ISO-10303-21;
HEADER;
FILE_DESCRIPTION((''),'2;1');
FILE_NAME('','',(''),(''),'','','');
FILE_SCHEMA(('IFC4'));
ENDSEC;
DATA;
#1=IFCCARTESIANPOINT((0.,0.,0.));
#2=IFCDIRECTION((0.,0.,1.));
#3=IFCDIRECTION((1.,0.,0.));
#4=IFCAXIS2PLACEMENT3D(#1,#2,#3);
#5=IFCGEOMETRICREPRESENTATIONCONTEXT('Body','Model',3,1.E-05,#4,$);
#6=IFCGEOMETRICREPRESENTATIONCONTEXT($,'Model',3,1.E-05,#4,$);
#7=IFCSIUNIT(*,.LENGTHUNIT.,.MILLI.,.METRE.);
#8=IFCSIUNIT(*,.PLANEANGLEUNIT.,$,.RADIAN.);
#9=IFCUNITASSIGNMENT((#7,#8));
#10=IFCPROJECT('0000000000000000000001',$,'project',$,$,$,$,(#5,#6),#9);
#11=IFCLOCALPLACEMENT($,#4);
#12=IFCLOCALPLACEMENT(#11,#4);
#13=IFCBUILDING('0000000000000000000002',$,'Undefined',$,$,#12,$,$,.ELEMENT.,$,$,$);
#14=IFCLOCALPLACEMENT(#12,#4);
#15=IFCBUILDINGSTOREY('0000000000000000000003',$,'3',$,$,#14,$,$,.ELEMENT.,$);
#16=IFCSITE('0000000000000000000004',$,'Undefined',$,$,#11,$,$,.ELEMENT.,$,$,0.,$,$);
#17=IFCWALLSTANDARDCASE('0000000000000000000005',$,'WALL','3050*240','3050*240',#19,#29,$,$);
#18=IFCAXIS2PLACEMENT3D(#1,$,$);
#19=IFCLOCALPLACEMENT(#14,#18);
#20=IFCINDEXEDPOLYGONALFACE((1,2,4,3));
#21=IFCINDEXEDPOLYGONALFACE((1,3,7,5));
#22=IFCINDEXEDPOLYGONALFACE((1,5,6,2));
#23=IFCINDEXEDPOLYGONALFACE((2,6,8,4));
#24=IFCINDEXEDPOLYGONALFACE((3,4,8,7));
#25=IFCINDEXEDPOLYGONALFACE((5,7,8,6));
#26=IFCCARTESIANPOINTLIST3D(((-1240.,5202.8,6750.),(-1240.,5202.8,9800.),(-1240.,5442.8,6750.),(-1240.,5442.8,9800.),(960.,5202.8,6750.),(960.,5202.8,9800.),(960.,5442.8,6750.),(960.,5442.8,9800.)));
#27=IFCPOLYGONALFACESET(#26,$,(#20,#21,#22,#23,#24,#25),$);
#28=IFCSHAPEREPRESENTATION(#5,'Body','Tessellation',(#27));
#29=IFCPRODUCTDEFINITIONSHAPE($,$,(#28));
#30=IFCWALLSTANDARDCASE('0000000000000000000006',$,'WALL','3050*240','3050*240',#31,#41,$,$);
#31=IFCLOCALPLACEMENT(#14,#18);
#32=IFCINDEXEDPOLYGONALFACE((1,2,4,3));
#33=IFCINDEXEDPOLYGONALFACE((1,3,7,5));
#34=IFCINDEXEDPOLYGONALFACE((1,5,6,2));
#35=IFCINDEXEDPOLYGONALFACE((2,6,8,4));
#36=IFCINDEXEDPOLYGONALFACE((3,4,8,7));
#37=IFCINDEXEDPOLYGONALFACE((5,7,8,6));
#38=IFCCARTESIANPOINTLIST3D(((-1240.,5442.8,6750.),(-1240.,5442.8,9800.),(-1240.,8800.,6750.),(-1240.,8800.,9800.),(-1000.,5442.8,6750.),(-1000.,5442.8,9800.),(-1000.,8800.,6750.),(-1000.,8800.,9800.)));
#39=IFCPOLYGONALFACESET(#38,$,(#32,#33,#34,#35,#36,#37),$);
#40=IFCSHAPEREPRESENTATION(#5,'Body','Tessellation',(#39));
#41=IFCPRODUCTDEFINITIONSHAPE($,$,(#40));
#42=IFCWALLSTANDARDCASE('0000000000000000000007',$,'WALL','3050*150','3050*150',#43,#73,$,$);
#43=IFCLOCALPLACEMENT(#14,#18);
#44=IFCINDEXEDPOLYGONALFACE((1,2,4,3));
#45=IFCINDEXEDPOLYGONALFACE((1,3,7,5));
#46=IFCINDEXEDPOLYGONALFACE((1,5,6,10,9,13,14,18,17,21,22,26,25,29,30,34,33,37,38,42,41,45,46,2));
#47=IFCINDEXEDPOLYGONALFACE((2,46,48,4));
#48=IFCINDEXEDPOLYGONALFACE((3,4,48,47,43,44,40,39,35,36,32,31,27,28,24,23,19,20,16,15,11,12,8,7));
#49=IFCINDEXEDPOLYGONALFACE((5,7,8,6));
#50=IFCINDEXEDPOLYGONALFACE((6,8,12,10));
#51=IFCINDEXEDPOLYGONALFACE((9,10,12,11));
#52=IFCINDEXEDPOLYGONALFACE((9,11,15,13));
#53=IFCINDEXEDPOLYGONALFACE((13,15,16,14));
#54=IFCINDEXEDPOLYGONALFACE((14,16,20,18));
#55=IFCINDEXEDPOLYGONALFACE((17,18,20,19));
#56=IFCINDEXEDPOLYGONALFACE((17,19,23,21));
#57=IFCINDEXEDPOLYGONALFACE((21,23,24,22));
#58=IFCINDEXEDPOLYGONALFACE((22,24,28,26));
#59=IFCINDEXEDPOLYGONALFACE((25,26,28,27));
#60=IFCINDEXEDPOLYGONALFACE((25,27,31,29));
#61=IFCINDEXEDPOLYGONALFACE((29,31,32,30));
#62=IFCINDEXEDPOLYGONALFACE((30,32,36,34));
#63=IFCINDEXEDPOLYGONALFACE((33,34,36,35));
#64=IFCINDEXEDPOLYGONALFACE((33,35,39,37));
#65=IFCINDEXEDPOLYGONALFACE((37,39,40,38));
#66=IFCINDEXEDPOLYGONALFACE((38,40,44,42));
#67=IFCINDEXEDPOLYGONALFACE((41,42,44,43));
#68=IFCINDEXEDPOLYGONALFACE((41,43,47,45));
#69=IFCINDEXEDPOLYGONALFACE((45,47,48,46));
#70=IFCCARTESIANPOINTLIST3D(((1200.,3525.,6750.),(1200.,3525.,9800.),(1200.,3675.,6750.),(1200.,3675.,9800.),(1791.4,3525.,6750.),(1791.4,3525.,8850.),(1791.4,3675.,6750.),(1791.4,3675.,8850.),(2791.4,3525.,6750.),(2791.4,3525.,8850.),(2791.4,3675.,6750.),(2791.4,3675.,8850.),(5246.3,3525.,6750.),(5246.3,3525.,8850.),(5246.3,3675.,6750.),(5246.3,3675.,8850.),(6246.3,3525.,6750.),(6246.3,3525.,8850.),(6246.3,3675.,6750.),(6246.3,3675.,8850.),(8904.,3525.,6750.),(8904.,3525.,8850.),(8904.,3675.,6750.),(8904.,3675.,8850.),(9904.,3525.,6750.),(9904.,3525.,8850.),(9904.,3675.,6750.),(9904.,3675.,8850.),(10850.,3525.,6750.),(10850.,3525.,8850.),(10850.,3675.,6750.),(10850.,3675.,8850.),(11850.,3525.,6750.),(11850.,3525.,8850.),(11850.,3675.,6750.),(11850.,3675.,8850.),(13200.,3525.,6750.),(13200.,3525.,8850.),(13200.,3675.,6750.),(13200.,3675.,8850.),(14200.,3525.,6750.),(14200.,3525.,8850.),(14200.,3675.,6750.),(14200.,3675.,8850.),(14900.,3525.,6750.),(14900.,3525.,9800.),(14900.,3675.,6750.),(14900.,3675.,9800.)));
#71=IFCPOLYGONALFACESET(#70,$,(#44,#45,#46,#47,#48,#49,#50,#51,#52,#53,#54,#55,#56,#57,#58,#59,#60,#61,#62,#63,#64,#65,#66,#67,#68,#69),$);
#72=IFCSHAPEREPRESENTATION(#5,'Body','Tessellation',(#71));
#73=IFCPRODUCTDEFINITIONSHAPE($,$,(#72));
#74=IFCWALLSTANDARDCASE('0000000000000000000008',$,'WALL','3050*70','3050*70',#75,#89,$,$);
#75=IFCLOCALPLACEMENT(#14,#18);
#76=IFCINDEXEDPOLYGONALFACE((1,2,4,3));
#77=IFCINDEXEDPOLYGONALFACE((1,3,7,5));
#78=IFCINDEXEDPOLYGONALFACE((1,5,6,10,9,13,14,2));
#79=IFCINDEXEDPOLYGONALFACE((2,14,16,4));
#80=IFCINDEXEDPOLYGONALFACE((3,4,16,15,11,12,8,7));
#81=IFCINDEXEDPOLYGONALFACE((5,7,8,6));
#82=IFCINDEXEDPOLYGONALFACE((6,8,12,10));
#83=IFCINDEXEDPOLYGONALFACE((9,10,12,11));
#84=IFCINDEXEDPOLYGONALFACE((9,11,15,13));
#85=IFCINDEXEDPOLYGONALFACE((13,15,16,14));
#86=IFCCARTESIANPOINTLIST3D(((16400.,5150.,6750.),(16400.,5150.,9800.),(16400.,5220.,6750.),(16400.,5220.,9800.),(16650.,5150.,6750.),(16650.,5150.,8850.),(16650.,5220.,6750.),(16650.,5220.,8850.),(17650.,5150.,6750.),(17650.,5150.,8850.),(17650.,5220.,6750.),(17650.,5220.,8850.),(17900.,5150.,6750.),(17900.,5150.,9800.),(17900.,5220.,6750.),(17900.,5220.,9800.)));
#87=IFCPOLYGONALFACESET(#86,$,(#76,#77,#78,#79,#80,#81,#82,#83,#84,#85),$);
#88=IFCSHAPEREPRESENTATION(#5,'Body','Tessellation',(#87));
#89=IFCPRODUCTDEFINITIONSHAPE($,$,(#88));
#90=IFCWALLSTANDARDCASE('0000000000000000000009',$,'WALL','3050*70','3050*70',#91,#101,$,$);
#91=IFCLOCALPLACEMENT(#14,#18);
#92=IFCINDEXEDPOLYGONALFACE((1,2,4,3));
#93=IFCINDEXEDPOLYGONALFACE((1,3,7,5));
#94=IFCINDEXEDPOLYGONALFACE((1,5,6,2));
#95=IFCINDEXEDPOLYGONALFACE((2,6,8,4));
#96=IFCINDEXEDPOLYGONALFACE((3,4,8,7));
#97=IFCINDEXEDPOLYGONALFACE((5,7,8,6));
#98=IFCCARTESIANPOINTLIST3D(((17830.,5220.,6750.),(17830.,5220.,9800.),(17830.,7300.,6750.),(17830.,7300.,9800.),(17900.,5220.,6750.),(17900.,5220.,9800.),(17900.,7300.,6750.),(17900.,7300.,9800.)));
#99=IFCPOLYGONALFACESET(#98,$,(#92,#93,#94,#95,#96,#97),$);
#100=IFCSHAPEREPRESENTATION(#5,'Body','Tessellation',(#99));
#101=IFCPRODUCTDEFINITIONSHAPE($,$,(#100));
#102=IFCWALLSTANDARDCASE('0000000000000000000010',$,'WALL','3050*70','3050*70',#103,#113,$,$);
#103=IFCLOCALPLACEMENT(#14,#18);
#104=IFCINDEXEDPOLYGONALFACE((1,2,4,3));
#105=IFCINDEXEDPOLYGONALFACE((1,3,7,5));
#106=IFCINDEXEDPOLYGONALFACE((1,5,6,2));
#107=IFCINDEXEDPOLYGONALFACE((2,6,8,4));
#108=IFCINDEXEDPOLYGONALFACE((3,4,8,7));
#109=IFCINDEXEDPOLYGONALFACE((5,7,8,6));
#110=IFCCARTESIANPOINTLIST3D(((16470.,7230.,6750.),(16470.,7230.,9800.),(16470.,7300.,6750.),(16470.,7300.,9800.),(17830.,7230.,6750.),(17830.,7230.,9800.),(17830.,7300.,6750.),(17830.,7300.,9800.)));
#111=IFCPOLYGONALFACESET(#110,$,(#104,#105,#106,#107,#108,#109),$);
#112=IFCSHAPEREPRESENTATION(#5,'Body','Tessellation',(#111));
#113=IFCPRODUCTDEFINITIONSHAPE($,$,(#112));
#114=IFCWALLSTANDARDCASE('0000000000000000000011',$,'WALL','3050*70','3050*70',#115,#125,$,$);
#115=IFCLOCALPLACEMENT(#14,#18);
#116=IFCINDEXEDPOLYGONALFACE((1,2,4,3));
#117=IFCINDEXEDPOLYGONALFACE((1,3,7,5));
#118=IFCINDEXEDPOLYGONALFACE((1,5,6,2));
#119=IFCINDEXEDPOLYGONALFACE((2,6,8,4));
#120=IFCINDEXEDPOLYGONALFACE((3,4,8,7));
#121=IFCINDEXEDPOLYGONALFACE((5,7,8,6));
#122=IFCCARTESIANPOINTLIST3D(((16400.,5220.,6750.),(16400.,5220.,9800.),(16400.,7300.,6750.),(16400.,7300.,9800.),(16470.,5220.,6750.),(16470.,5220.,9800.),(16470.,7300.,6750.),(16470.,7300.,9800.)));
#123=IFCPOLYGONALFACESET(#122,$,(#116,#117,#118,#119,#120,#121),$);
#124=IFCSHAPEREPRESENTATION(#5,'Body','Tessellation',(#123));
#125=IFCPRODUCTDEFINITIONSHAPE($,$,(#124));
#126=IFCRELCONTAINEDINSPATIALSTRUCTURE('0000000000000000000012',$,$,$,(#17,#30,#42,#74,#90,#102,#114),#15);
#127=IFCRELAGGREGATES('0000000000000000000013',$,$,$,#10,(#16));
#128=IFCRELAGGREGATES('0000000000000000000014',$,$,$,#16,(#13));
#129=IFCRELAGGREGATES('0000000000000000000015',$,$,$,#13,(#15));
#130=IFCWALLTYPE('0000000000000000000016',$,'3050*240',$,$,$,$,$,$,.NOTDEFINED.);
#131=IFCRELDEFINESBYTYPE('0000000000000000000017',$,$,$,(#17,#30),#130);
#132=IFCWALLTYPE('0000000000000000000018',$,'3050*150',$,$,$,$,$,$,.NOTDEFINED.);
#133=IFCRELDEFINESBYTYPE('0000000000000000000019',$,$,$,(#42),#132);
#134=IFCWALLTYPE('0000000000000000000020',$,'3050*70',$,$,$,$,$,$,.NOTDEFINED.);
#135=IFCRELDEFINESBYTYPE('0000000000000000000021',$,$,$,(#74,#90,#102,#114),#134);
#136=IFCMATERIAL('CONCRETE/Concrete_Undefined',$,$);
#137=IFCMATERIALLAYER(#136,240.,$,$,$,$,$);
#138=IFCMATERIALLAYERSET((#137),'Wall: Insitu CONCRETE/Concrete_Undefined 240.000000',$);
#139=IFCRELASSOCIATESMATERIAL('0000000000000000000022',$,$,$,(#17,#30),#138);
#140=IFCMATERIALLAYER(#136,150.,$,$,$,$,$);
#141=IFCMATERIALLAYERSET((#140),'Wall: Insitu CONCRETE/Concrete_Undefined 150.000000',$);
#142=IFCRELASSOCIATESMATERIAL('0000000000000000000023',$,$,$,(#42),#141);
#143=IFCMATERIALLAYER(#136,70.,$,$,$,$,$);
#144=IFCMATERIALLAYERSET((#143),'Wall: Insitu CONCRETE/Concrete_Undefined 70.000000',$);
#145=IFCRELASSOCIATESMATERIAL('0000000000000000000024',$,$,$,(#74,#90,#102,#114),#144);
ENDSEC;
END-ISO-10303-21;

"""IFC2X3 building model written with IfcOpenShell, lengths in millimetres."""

from ifc_helpers import new_model, si_unit, frame, frame_2d, origin_with_axes, place, context, project, spatial, polyline, rectangle, outline, extrude, material, layer, layer_set, layer_usage, type_object, element, save


model = new_model("IFC2X3")

# Units and contexts
model_context_1 = context("Model", 3, precision=1e-05, world=origin_with_axes(), identifier="Body")
model_context_2 = context("Model", 3, precision=1e-05, world=origin_with_axes())
ifc_project = project(units=[si_unit("LENGTHUNIT", "METRE", prefix="MILLI"), si_unit("PLANEANGLEUNIT", "RADIAN")], contexts=[model_context_1, model_context_2])

# Site, building, storey
site_placement = place(None, origin_with_axes())
site = spatial("IfcSite", under=ifc_project, at=site_placement, Name="Undefined", CompositionType="ELEMENT", RefElevation=0.0)
building_placement = place(site_placement, origin_with_axes())
building = spatial("IfcBuilding", under=site, at=building_placement, Name="Undefined", CompositionType="ELEMENT")
storey_placement = place(building_placement, origin_with_axes())
storey = spatial("IfcBuildingStorey", under=building, at=storey_placement, Name="3", CompositionType="ELEMENT")

# Shared definitions
ifc_material = material(Name="CONCRETE/Concrete_Undefined")

# Shared definitions
ifc_layer_1 = layer(ifc_material, 240.0)
ifc_layer_set_1 = layer_set([ifc_layer_1], Name="Wall: Insitu CONCRETE/Concrete_Undefined 240.000000")
wall_type_1 = type_object("IfcWallType", Name="3050*240", PredefinedType="NOTDEFINED")

# Walls
ifc_layer_usage_1 = layer_usage(ifc_layer_set_1, "AXIS2", "POSITIVE", -120.0)
wall_1_placement = place(storey_placement, frame((960.0, 5322.8, 6750.0), z_axis=(0.0, 0.0, 1.0), x_axis=(-1.0, 0.0, 0.0)))
element("IfcWallStandardCase", 1, at=wall_1_placement, inside=storey, type_object=wall_type_1, material=ifc_layer_usage_1, Name="WALL", Description="3050*240", ObjectType="3050*240", context=model_context_1, shape_type="SweptSolid", body=[
    extrude(rectangle(XDim=2200.0, YDim=240.0, at=frame_2d((0.0, 1100.0), x_axis=(0.0, -1.0))), frame((0.0, 0.0, 0.0), z_axis=(0.0, 0.0, 1.0), x_axis=(0.0, -1.0, 0.0)), (0.0, 0.0, 1.0), 3050.0),
])
ifc_layer_usage_2 = layer_usage(ifc_layer_set_1, "AXIS2", "POSITIVE", -120.0)
wall_2_placement = place(storey_placement, frame((-1120.0, 5442.8, 6750.0), z_axis=(0.0, 0.0, 1.0), x_axis=(0.0, 1.0, 0.0)))
element("IfcWallStandardCase", 2, at=wall_2_placement, inside=storey, type_object=wall_type_1, material=ifc_layer_usage_2, Name="WALL", Description="3050*240", ObjectType="3050*240", context=model_context_1, shape_type="SweptSolid", body=[
    extrude(rectangle(XDim=3357.2, YDim=240.0, at=frame_2d((0.0, 1678.6), x_axis=(0.0, -1.0))), frame((0.0, 0.0, 0.0), z_axis=(0.0, 0.0, 1.0), x_axis=(0.0, -1.0, 0.0)), (0.0, 0.0, 1.0), 3050.0),
])

# Wall, openings
ifc_layer_2 = layer(ifc_material, 150.0)
ifc_layer_set_2 = layer_set([ifc_layer_2], Name="Wall: Insitu CONCRETE/Concrete_Undefined 150.000000")
ifc_layer_usage_3 = layer_usage(ifc_layer_set_2, "AXIS2", "POSITIVE", -75.0)
wall_type_2 = type_object("IfcWallType", Name="3050*150", PredefinedType="NOTDEFINED")
wall_3_placement = place(storey_placement, frame((1200.0, 3600.0, 6750.0), z_axis=(0.0, 0.0, 1.0), x_axis=(1.0, 0.0, 0.0)))
wall_3 = element("IfcWallStandardCase", 3, at=wall_3_placement, inside=storey, type_object=wall_type_2, material=ifc_layer_usage_3, Name="WALL", Description="3050*150", ObjectType="3050*150", context=model_context_1, shape_type="SweptSolid", body=[
    extrude(rectangle(XDim=13700.0, YDim=150.0, at=frame_2d((0.0, 6850.0), x_axis=(0.0, -1.0))), frame((0.0, 0.0, 0.0), z_axis=(0.0, 0.0, 1.0), x_axis=(0.0, -1.0, 0.0)), (0.0, 0.0, 1.0), 3050.0),
])
opening_1_placement = place(storey_placement, frame((1200.0, 3600.0, 6750.0), z_axis=(0.0, 0.0, 1.0), x_axis=(1.0, 0.0, 0.0)))
element("IfcOpeningElement", 4, at=opening_1_placement, cuts=wall_3, ObjectType="Recess", context=model_context_1, shape_type="SweptSolid", body=[
    extrude(outline(polyline([(0.0, 0.0), (1000.0, 0.0), (1000.0, 2100.0), (0.0, 2100.0), (0.0, 0.0)])), frame((591.4, -78.0, 2100.0), z_axis=(0.0, 1.0, 0.0), x_axis=(1.0, 0.0, 0.0)), (0.0, 0.0, 1.0), 156.0),
])
opening_2_placement = place(storey_placement, frame((1200.0, 3600.0, 6750.0), z_axis=(0.0, 0.0, 1.0), x_axis=(1.0, 0.0, 0.0)))
element("IfcOpeningElement", 5, at=opening_2_placement, cuts=wall_3, ObjectType="Recess", context=model_context_1, shape_type="SweptSolid", body=[
    extrude(outline(polyline([(0.0, 0.0), (1000.0, 0.0), (1000.0, 2100.0), (0.0, 2100.0), (0.0, 0.0)])), frame((4046.3, -78.0, 2100.0), z_axis=(0.0, 1.0, 0.0), x_axis=(1.0, 0.0, 0.0)), (0.0, 0.0, 1.0), 156.0),
])
opening_3_placement = place(storey_placement, frame((1200.0, 3600.0, 6750.0), z_axis=(0.0, 0.0, 1.0), x_axis=(1.0, 0.0, 0.0)))
element("IfcOpeningElement", 6, at=opening_3_placement, cuts=wall_3, ObjectType="Recess", context=model_context_1, shape_type="SweptSolid", body=[
    extrude(outline(polyline([(0.0, 0.0), (1000.0, 0.0), (1000.0, 2100.0), (0.0, 2100.0), (0.0, 0.0)])), frame((7704.0, -78.0, 2100.0), z_axis=(0.0, 1.0, 0.0), x_axis=(1.0, 0.0, 0.0)), (0.0, 0.0, 1.0), 156.0),
])
opening_4_placement = place(storey_placement, frame((1200.0, 3600.0, 6750.0), z_axis=(0.0, 0.0, 1.0), x_axis=(1.0, 0.0, 0.0)))
element("IfcOpeningElement", 7, at=opening_4_placement, cuts=wall_3, ObjectType="Recess", context=model_context_1, shape_type="SweptSolid", body=[
    extrude(outline(polyline([(0.0, 0.0), (1000.0, 0.0), (1000.0, 2100.0), (0.0, 2100.0), (0.0, 0.0)])), frame((9650.0, -78.0, 2100.0), z_axis=(0.0, 1.0, 0.0), x_axis=(1.0, 0.0, 0.0)), (0.0, 0.0, 1.0), 156.0),
])
opening_5_placement = place(storey_placement, frame((1200.0, 3600.0, 6750.0), z_axis=(0.0, 0.0, 1.0), x_axis=(1.0, 0.0, 0.0)))
element("IfcOpeningElement", 8, at=opening_5_placement, cuts=wall_3, ObjectType="Recess", context=model_context_1, shape_type="SweptSolid", body=[
    extrude(outline(polyline([(0.0, 0.0), (1000.0, 0.0), (1000.0, 2100.0), (0.0, 2100.0), (0.0, 0.0)])), frame((12000.0, -78.0, 2100.0), z_axis=(0.0, 1.0, 0.0), x_axis=(1.0, 0.0, 0.0)), (0.0, 0.0, 1.0), 156.0),
])

# Wall, opening
ifc_layer_3 = layer(ifc_material, 70.0)
ifc_layer_set_3 = layer_set([ifc_layer_3], Name="Wall: Insitu CONCRETE/Concrete_Undefined 70.000000")
ifc_layer_usage_4 = layer_usage(ifc_layer_set_3, "AXIS2", "POSITIVE", -35.0)
wall_type_3 = type_object("IfcWallType", Name="3050*70", PredefinedType="NOTDEFINED")
wall_4_placement = place(storey_placement, frame((16400.0, 5185.0, 6750.0), z_axis=(0.0, 0.0, 1.0), x_axis=(1.0, 0.0, 0.0)))
wall_4 = element("IfcWallStandardCase", 9, at=wall_4_placement, inside=storey, type_object=wall_type_3, material=ifc_layer_usage_4, Name="WALL", Description="3050*70", ObjectType="3050*70", context=model_context_1, shape_type="SweptSolid", body=[
    extrude(rectangle(XDim=1500.0, YDim=70.0, at=frame_2d((0.0, 750.0), x_axis=(0.0, -1.0))), frame((0.0, 0.0, 0.0), z_axis=(0.0, 0.0, 1.0), x_axis=(0.0, -1.0, 0.0)), (0.0, 0.0, 1.0), 3050.0),
])
opening_6_placement = place(storey_placement, frame((16400.0, 5185.0, 6750.0), z_axis=(0.0, 0.0, 1.0), x_axis=(1.0, 0.0, 0.0)))
element("IfcOpeningElement", 10, at=opening_6_placement, cuts=wall_4, ObjectType="Recess", context=model_context_1, shape_type="SweptSolid", body=[
    extrude(outline(polyline([(0.0, 0.0), (2100.0, 0.0), (2100.0, 1000.0), (0.0, 1000.0), (0.0, 0.0)])), frame((250.0, -38.0, 0.0), z_axis=(0.0, 1.0, 0.0), x_axis=(0.0, 0.0, 1.0)), (0.0, 0.0, 1.0), 76.0),
])

# Walls
ifc_layer_usage_5 = layer_usage(ifc_layer_set_3, "AXIS2", "POSITIVE", -35.0)
wall_5_placement = place(storey_placement, frame((17865.0, 5220.0, 6750.0), z_axis=(0.0, 0.0, 1.0), x_axis=(0.0, 1.0, 0.0)))
element("IfcWallStandardCase", 11, at=wall_5_placement, inside=storey, type_object=wall_type_3, material=ifc_layer_usage_5, Name="WALL", Description="3050*70", ObjectType="3050*70", context=model_context_1, shape_type="SweptSolid", body=[
    extrude(rectangle(XDim=2080.0, YDim=70.0, at=frame_2d((0.0, 1040.0), x_axis=(0.0, -1.0))), frame((0.0, 0.0, 0.0), z_axis=(0.0, 0.0, 1.0), x_axis=(0.0, -1.0, 0.0)), (0.0, 0.0, 1.0), 3050.0),
])
ifc_layer_usage_6 = layer_usage(ifc_layer_set_3, "AXIS2", "POSITIVE", -35.0)
wall_6_placement = place(storey_placement, frame((17830.0, 7265.0, 6750.0), z_axis=(0.0, 0.0, 1.0), x_axis=(-1.0, 0.0, 0.0)))
element("IfcWallStandardCase", 12, at=wall_6_placement, inside=storey, type_object=wall_type_3, material=ifc_layer_usage_6, Name="WALL", Description="3050*70", ObjectType="3050*70", context=model_context_1, shape_type="SweptSolid", body=[
    extrude(rectangle(XDim=1360.0, YDim=70.0, at=frame_2d((0.0, 680.0), x_axis=(0.0, -1.0))), frame((0.0, 0.0, 0.0), z_axis=(0.0, 0.0, 1.0), x_axis=(0.0, -1.0, 0.0)), (0.0, 0.0, 1.0), 3050.0),
])
ifc_layer_usage_7 = layer_usage(ifc_layer_set_3, "AXIS2", "POSITIVE", -35.0)
wall_7_placement = place(storey_placement, frame((16435.0, 7300.0, 6750.0), z_axis=(0.0, 0.0, 1.0), x_axis=(0.0, -1.0, 0.0)))
element("IfcWallStandardCase", 13, at=wall_7_placement, inside=storey, type_object=wall_type_3, material=ifc_layer_usage_7, Name="WALL", Description="3050*70", ObjectType="3050*70", context=model_context_1, shape_type="SweptSolid", body=[
    extrude(rectangle(XDim=2080.0, YDim=70.0, at=frame_2d((0.0, 1040.0), x_axis=(0.0, -1.0))), frame((0.0, 0.0, 0.0), z_axis=(0.0, 0.0, 1.0), x_axis=(0.0, -1.0, 0.0)), (0.0, 0.0, 1.0), 3050.0),
])

save(model, "model.ifc")
